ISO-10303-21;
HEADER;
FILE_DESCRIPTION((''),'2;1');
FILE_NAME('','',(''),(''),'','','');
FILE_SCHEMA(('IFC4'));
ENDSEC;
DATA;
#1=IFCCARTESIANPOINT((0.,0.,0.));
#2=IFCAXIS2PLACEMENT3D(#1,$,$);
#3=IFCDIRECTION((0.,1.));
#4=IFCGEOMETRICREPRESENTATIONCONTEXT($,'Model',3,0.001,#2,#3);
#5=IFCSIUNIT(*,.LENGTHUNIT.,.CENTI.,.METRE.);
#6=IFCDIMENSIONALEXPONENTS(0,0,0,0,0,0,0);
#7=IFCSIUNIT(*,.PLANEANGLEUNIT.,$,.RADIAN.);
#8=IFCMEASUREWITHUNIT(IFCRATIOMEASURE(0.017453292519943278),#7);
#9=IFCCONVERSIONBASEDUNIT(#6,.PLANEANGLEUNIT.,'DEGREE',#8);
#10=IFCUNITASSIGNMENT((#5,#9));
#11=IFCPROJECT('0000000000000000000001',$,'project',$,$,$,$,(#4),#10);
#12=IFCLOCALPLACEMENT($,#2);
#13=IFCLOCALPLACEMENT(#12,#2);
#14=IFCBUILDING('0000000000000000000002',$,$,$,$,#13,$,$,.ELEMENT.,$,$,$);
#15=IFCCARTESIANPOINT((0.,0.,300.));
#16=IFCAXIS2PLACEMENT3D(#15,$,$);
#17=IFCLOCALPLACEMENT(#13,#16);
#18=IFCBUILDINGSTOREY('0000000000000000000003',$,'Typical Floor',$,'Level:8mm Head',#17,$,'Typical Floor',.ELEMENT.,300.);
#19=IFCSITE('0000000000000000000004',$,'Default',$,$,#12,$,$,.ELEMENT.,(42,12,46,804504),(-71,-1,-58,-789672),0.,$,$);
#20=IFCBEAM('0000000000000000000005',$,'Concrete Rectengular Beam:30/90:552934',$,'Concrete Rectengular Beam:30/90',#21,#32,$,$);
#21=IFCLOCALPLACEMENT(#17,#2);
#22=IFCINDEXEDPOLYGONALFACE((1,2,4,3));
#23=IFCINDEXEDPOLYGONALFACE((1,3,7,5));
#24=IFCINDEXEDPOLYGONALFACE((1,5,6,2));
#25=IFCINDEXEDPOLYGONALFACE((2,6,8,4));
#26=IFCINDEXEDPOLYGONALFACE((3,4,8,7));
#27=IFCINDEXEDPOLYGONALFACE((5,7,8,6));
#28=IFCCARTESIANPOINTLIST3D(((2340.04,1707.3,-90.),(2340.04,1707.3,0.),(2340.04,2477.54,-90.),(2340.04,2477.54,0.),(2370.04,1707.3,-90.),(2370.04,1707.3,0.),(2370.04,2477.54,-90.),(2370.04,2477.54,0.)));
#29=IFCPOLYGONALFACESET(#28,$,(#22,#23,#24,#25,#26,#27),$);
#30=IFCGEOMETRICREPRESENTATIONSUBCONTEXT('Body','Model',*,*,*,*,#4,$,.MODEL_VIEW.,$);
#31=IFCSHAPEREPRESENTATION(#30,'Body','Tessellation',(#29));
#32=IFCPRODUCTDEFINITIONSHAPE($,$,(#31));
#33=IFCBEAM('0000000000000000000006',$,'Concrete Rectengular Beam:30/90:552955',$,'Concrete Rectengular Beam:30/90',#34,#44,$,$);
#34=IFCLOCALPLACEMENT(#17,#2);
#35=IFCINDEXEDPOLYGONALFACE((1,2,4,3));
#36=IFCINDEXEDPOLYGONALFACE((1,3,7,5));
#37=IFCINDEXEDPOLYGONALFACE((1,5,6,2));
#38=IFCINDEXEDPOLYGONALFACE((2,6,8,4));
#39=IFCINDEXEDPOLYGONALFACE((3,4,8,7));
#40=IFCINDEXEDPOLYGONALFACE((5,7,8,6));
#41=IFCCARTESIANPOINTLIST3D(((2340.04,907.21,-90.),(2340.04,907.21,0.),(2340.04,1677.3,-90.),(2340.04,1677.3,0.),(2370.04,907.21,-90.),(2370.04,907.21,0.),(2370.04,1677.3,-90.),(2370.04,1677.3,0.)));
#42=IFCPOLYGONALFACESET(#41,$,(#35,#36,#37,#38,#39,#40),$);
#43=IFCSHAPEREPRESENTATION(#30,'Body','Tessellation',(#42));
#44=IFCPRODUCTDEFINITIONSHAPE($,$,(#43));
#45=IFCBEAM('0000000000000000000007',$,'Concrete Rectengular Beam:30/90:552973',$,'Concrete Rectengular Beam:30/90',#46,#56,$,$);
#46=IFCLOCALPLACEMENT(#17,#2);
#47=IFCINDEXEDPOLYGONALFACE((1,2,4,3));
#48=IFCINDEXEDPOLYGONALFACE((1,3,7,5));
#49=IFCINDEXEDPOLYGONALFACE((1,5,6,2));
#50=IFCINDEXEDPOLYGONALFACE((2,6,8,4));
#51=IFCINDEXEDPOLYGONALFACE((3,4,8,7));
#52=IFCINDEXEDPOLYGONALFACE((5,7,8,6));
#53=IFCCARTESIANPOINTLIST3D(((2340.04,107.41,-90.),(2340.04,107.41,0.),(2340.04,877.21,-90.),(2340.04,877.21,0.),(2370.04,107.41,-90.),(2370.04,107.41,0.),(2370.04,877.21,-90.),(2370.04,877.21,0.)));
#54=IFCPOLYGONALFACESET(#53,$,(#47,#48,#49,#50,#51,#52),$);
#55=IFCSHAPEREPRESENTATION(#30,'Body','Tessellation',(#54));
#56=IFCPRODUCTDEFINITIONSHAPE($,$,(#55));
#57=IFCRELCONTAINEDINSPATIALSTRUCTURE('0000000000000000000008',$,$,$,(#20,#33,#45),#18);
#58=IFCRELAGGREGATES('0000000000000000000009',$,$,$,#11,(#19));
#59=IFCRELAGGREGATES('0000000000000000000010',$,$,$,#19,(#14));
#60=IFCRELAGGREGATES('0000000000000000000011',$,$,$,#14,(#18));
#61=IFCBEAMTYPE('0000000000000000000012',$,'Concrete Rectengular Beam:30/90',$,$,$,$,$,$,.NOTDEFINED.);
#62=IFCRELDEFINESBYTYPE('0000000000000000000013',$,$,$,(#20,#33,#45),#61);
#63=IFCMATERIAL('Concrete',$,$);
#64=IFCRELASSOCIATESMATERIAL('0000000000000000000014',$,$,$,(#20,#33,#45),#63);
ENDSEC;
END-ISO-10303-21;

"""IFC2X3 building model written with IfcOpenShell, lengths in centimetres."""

from ifc_helpers import new_model, entity, si_unit, converted_unit, direction, frame, frame_2d, origin, place, context, subcontext, project, spatial, rectangle, extrude, material, type_object, element, save


model = new_model("IFC2X3")

# Units and contexts
model_context = context("Model", 3, precision=0.001, world=origin(), true_north=direction((0.0, 1.0)))
body_context = subcontext(model_context, "Body", "Model", "MODEL_VIEW")
ifc_project = project(units=[si_unit("LENGTHUNIT", "METRE", prefix="CENTI"), converted_unit("PLANEANGLEUNIT", "DEGREE", entity("IfcRatioMeasure", 0.017453292519943278), si_unit("PLANEANGLEUNIT", "RADIAN"), dimensions=[0, 0, 0, 0, 0, 0, 0])], contexts=[model_context])

# Site, building, storey
site_placement = place(None, origin())
site = spatial("IfcSite", under=ifc_project, at=site_placement, Name="Default", CompositionType="ELEMENT", RefLatitude=(42, 12, 46, 804504), RefLongitude=(-71, -1, -58, -789672), RefElevation=0.0)
building_placement = place(site_placement, origin())
building = spatial("IfcBuilding", under=site, at=building_placement, CompositionType="ELEMENT")
storey_placement = place(building_placement, frame((0.0, 0.0, 300.0)))
storey = spatial("IfcBuildingStorey", under=building, at=storey_placement, Name="Typical Floor", ObjectType="Level:8mm Head", LongName="Typical Floor", CompositionType="ELEMENT", Elevation=300.0)

# Beams
ifc_material = material(Name="Concrete")
beam_type_1 = type_object("IfcBeamType", Name="Concrete Rectengular Beam:30/90", PredefinedType="NOTDEFINED")
beam_1_placement = place(storey_placement, frame((2355.04, 2492.54, 0.0), z_axis=(0.0, 0.0, 1.0), x_axis=(0.0, -1.0, 0.0)))
element("IfcBeam", 1, at=beam_1_placement, inside=storey, type_object=beam_type_1, material=ifc_material, Name="Concrete Rectengular Beam:30/90:552934", ObjectType="Concrete Rectengular Beam:30/90", context=body_context, shape_type="SweptSolid", body=[
    extrude(rectangle(XDim=90.0, YDim=30.0, at=frame_2d((0.0, 0.0), x_axis=(1.0, 0.0))), frame((15.0, 0.0, -45.0), z_axis=(1.0, 0.0, 0.0), x_axis=(0.0, 0.0, -1.0)), (0.0, 0.0, 1.0), 770.24),
])
beam_2_placement = place(storey_placement, frame((2355.04, 1692.3, 0.0), z_axis=(0.0, 0.0, 1.0), x_axis=(0.0, -1.0, 0.0)))
element("IfcBeam", 2, at=beam_2_placement, inside=storey, type_object=beam_type_1, material=ifc_material, Name="Concrete Rectengular Beam:30/90:552955", ObjectType="Concrete Rectengular Beam:30/90", context=body_context, shape_type="SweptSolid", body=[
    extrude(rectangle(XDim=90.0, YDim=30.0, at=frame_2d((0.0, 0.0), x_axis=(1.0, 0.0))), frame((15.0, 0.0, -45.0), z_axis=(1.0, 0.0, 0.0), x_axis=(0.0, 0.0, -1.0)), (0.0, 0.0, 1.0), 770.09),
])
beam_3_placement = place(storey_placement, frame((2355.04, 892.21, 0.0), z_axis=(0.0, 0.0, 1.0), x_axis=(0.0, -1.0, 0.0)))
element("IfcBeam", 3, at=beam_3_placement, inside=storey, type_object=beam_type_1, material=ifc_material, Name="Concrete Rectengular Beam:30/90:552973", ObjectType="Concrete Rectengular Beam:30/90", context=body_context, shape_type="SweptSolid", body=[
    extrude(rectangle(XDim=90.0, YDim=30.0, at=frame_2d((0.0, 0.0), x_axis=(1.0, 0.0))), frame((15.0, 0.0, -45.0), z_axis=(1.0, 0.0, 0.0), x_axis=(0.0, 0.0, -1.0)), (0.0, 0.0, 1.0), 769.8),
])

save(model, "model.ifc")
